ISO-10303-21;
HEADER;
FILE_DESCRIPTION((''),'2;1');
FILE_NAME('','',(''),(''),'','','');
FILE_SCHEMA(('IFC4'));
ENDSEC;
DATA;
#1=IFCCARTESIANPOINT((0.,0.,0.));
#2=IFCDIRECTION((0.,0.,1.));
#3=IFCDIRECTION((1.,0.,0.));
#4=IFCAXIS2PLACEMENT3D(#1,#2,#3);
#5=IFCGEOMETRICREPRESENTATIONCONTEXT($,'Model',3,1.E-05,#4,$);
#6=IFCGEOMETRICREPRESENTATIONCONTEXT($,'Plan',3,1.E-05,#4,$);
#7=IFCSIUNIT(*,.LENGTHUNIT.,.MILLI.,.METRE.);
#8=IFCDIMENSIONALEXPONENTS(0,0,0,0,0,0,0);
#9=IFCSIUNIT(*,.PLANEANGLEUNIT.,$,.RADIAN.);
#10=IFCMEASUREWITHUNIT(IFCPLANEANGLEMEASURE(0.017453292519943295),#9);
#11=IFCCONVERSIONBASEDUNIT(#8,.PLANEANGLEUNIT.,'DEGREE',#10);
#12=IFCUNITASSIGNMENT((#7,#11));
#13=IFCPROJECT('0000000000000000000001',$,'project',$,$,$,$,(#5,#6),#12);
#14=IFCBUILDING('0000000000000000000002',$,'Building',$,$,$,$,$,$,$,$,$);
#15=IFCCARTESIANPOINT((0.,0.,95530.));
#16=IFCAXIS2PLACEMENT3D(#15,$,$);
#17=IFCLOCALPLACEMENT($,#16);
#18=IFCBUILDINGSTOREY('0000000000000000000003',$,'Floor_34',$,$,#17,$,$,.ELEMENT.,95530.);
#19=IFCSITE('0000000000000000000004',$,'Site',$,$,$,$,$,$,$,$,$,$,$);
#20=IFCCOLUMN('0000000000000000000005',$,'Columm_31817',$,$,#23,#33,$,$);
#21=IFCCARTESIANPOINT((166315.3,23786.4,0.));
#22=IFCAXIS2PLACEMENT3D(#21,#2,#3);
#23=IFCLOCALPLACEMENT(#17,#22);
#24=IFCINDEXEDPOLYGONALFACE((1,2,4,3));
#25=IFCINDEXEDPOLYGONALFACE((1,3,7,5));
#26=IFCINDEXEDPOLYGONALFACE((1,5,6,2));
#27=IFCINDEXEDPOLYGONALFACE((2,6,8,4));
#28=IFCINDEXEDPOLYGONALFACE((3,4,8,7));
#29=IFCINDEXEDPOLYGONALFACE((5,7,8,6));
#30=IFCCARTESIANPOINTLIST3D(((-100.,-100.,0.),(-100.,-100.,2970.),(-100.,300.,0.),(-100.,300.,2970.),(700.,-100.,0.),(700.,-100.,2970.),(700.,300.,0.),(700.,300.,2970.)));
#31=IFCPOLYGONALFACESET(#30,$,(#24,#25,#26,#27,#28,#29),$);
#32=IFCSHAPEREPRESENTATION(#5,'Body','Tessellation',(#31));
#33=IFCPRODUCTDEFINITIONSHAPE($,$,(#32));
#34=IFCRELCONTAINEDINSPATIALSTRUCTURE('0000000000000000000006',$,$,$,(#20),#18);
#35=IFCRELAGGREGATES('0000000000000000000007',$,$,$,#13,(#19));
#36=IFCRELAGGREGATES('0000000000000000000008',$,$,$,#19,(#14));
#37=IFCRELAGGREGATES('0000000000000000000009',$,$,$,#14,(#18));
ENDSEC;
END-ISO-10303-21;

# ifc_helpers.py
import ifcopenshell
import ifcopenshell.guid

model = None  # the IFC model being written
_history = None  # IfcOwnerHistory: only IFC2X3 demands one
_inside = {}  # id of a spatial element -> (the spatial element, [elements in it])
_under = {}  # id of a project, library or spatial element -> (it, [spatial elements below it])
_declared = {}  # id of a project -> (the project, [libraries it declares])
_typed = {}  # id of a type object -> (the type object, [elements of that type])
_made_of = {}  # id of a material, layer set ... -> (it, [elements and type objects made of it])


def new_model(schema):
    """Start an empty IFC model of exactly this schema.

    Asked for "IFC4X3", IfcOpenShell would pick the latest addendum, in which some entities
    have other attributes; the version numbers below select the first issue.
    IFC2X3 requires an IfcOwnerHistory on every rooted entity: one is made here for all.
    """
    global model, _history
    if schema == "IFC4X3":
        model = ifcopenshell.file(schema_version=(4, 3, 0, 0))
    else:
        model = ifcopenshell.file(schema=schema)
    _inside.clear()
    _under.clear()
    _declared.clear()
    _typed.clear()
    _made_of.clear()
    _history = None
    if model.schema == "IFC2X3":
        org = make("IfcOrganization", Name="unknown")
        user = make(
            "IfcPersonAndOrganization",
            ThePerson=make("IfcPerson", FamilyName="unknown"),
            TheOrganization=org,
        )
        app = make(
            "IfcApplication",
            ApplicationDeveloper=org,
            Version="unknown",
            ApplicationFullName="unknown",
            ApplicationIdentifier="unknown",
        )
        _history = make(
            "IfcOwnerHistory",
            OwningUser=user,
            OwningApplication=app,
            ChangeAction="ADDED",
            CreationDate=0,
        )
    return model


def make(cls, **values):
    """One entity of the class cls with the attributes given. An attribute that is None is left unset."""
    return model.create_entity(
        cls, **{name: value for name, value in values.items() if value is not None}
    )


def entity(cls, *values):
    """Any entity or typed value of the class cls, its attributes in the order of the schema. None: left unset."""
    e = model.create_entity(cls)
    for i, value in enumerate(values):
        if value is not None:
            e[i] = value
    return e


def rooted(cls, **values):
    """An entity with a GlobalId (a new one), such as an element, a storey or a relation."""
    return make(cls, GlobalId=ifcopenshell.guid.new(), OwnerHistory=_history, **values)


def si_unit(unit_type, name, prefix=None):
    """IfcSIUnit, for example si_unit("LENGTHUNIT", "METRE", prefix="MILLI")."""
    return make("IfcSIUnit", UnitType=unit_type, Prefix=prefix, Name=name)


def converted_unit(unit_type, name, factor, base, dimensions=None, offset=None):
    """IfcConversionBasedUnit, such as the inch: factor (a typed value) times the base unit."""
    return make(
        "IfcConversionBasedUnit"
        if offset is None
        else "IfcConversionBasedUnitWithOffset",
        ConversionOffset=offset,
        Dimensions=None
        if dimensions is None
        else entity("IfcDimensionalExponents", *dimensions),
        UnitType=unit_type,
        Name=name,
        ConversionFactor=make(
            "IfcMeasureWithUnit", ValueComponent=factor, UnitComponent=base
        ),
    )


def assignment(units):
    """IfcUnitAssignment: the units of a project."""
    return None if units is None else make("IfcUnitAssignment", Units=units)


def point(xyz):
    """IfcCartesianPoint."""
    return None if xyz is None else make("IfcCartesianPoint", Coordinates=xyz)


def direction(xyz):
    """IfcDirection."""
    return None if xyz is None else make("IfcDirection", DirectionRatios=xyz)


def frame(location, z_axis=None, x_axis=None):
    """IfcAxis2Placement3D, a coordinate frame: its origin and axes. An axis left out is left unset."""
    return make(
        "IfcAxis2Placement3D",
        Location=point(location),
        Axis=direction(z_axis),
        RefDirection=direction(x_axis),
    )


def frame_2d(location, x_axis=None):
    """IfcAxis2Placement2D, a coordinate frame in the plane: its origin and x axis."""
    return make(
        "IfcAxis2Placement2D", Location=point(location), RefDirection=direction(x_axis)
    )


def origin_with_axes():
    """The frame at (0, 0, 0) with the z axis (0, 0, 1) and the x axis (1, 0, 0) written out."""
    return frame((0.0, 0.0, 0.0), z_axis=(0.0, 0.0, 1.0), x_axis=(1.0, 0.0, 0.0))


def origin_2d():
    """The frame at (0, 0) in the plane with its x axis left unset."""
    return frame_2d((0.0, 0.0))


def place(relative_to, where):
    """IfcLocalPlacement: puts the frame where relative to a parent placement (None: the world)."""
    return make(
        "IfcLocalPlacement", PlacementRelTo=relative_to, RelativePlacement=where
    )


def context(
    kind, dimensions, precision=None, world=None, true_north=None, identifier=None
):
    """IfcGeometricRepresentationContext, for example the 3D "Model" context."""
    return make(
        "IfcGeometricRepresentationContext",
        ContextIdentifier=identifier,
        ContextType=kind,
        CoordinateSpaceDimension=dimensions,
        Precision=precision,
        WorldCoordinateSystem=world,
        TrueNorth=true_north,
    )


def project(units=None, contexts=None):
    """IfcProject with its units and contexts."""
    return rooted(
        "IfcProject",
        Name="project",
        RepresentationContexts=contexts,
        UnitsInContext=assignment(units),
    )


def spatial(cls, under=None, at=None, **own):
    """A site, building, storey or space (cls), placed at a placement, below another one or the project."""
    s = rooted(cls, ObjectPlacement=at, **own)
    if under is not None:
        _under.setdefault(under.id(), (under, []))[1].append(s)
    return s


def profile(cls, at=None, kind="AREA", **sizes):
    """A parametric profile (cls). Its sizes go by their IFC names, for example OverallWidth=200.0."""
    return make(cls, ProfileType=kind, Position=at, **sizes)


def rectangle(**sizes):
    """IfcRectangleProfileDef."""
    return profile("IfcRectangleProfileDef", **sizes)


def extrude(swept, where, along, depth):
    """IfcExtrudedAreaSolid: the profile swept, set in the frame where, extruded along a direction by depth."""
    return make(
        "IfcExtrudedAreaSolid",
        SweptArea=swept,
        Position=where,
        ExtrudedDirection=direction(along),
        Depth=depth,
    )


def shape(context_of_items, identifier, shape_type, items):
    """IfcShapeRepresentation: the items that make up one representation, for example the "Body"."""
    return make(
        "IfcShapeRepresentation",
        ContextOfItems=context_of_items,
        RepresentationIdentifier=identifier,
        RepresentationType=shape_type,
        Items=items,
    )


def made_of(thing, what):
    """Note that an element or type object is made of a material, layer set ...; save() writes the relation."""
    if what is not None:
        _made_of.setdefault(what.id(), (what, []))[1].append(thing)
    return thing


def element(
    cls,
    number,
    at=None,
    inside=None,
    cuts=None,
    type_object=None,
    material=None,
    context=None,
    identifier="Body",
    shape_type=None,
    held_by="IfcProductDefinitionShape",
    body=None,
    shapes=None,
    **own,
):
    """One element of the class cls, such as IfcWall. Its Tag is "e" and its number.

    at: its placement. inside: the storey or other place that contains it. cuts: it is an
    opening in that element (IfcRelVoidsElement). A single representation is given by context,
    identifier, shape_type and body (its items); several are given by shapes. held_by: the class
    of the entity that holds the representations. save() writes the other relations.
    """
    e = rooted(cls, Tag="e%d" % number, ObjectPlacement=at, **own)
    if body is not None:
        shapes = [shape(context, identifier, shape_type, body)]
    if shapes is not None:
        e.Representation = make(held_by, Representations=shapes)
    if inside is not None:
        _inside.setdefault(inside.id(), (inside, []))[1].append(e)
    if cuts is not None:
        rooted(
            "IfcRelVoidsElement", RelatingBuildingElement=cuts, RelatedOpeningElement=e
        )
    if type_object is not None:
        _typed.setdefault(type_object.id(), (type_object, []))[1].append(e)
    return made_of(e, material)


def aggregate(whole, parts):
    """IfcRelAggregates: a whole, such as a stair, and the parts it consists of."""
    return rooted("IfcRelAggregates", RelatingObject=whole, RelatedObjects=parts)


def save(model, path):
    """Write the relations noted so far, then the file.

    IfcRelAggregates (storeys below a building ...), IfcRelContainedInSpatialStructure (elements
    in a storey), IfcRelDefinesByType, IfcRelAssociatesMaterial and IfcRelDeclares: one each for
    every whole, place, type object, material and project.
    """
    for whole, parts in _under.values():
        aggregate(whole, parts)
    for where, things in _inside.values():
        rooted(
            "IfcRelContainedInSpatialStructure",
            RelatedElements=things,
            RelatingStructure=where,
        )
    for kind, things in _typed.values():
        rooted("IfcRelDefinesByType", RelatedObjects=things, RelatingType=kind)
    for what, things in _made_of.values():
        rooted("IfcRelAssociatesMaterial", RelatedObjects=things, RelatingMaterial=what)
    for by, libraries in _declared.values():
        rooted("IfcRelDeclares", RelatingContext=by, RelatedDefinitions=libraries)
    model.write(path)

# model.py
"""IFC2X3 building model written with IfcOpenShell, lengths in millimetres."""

from ifc_helpers import new_model, entity, si_unit, converted_unit, frame, origin_with_axes, origin_2d, place, context, project, spatial, rectangle, extrude, element, save


model = new_model("IFC2X3")

# Units and contexts
model_context = context("Model", 3, precision=1e-05, world=origin_with_axes())
plan_context = context("Plan", 3, precision=1e-05, world=origin_with_axes())
ifc_project = project(units=[si_unit("LENGTHUNIT", "METRE", prefix="MILLI"), converted_unit("PLANEANGLEUNIT", "DEGREE", entity("IfcPlaneAngleMeasure", 0.017453292519943295), si_unit("PLANEANGLEUNIT", "RADIAN"), dimensions=[0, 0, 0, 0, 0, 0, 0])], contexts=[model_context, plan_context])

# Site, building, storey
site = spatial("IfcSite", under=ifc_project, Name="Site")
building = spatial("IfcBuilding", under=site, Name="Building")
storey_placement = place(None, frame((0.0, 0.0, 95530.0)))
storey = spatial("IfcBuildingStorey", under=building, at=storey_placement, Name="Floor_34", CompositionType="ELEMENT", Elevation=95530.0)

# Column
column_placement = place(storey_placement, frame((166315.3, 23786.4, 0.0), z_axis=(0.0, 0.0, 1.0), x_axis=(1.0, 0.0, 0.0)))
element("IfcColumn", 1, at=column_placement, inside=storey, Name="Columm_31817", context=model_context, shape_type="SweptSolid", body=[
    extrude(rectangle(XDim=800.0, YDim=400.0, at=origin_2d()), frame((300.0, 100.0, 0.0), z_axis=(0.0, 0.0, 1.0), x_axis=(1.0, 0.0, 0.0)), (0.0, 0.0, 1.0), 2970.0),
])

save(model, "model.ifc")
